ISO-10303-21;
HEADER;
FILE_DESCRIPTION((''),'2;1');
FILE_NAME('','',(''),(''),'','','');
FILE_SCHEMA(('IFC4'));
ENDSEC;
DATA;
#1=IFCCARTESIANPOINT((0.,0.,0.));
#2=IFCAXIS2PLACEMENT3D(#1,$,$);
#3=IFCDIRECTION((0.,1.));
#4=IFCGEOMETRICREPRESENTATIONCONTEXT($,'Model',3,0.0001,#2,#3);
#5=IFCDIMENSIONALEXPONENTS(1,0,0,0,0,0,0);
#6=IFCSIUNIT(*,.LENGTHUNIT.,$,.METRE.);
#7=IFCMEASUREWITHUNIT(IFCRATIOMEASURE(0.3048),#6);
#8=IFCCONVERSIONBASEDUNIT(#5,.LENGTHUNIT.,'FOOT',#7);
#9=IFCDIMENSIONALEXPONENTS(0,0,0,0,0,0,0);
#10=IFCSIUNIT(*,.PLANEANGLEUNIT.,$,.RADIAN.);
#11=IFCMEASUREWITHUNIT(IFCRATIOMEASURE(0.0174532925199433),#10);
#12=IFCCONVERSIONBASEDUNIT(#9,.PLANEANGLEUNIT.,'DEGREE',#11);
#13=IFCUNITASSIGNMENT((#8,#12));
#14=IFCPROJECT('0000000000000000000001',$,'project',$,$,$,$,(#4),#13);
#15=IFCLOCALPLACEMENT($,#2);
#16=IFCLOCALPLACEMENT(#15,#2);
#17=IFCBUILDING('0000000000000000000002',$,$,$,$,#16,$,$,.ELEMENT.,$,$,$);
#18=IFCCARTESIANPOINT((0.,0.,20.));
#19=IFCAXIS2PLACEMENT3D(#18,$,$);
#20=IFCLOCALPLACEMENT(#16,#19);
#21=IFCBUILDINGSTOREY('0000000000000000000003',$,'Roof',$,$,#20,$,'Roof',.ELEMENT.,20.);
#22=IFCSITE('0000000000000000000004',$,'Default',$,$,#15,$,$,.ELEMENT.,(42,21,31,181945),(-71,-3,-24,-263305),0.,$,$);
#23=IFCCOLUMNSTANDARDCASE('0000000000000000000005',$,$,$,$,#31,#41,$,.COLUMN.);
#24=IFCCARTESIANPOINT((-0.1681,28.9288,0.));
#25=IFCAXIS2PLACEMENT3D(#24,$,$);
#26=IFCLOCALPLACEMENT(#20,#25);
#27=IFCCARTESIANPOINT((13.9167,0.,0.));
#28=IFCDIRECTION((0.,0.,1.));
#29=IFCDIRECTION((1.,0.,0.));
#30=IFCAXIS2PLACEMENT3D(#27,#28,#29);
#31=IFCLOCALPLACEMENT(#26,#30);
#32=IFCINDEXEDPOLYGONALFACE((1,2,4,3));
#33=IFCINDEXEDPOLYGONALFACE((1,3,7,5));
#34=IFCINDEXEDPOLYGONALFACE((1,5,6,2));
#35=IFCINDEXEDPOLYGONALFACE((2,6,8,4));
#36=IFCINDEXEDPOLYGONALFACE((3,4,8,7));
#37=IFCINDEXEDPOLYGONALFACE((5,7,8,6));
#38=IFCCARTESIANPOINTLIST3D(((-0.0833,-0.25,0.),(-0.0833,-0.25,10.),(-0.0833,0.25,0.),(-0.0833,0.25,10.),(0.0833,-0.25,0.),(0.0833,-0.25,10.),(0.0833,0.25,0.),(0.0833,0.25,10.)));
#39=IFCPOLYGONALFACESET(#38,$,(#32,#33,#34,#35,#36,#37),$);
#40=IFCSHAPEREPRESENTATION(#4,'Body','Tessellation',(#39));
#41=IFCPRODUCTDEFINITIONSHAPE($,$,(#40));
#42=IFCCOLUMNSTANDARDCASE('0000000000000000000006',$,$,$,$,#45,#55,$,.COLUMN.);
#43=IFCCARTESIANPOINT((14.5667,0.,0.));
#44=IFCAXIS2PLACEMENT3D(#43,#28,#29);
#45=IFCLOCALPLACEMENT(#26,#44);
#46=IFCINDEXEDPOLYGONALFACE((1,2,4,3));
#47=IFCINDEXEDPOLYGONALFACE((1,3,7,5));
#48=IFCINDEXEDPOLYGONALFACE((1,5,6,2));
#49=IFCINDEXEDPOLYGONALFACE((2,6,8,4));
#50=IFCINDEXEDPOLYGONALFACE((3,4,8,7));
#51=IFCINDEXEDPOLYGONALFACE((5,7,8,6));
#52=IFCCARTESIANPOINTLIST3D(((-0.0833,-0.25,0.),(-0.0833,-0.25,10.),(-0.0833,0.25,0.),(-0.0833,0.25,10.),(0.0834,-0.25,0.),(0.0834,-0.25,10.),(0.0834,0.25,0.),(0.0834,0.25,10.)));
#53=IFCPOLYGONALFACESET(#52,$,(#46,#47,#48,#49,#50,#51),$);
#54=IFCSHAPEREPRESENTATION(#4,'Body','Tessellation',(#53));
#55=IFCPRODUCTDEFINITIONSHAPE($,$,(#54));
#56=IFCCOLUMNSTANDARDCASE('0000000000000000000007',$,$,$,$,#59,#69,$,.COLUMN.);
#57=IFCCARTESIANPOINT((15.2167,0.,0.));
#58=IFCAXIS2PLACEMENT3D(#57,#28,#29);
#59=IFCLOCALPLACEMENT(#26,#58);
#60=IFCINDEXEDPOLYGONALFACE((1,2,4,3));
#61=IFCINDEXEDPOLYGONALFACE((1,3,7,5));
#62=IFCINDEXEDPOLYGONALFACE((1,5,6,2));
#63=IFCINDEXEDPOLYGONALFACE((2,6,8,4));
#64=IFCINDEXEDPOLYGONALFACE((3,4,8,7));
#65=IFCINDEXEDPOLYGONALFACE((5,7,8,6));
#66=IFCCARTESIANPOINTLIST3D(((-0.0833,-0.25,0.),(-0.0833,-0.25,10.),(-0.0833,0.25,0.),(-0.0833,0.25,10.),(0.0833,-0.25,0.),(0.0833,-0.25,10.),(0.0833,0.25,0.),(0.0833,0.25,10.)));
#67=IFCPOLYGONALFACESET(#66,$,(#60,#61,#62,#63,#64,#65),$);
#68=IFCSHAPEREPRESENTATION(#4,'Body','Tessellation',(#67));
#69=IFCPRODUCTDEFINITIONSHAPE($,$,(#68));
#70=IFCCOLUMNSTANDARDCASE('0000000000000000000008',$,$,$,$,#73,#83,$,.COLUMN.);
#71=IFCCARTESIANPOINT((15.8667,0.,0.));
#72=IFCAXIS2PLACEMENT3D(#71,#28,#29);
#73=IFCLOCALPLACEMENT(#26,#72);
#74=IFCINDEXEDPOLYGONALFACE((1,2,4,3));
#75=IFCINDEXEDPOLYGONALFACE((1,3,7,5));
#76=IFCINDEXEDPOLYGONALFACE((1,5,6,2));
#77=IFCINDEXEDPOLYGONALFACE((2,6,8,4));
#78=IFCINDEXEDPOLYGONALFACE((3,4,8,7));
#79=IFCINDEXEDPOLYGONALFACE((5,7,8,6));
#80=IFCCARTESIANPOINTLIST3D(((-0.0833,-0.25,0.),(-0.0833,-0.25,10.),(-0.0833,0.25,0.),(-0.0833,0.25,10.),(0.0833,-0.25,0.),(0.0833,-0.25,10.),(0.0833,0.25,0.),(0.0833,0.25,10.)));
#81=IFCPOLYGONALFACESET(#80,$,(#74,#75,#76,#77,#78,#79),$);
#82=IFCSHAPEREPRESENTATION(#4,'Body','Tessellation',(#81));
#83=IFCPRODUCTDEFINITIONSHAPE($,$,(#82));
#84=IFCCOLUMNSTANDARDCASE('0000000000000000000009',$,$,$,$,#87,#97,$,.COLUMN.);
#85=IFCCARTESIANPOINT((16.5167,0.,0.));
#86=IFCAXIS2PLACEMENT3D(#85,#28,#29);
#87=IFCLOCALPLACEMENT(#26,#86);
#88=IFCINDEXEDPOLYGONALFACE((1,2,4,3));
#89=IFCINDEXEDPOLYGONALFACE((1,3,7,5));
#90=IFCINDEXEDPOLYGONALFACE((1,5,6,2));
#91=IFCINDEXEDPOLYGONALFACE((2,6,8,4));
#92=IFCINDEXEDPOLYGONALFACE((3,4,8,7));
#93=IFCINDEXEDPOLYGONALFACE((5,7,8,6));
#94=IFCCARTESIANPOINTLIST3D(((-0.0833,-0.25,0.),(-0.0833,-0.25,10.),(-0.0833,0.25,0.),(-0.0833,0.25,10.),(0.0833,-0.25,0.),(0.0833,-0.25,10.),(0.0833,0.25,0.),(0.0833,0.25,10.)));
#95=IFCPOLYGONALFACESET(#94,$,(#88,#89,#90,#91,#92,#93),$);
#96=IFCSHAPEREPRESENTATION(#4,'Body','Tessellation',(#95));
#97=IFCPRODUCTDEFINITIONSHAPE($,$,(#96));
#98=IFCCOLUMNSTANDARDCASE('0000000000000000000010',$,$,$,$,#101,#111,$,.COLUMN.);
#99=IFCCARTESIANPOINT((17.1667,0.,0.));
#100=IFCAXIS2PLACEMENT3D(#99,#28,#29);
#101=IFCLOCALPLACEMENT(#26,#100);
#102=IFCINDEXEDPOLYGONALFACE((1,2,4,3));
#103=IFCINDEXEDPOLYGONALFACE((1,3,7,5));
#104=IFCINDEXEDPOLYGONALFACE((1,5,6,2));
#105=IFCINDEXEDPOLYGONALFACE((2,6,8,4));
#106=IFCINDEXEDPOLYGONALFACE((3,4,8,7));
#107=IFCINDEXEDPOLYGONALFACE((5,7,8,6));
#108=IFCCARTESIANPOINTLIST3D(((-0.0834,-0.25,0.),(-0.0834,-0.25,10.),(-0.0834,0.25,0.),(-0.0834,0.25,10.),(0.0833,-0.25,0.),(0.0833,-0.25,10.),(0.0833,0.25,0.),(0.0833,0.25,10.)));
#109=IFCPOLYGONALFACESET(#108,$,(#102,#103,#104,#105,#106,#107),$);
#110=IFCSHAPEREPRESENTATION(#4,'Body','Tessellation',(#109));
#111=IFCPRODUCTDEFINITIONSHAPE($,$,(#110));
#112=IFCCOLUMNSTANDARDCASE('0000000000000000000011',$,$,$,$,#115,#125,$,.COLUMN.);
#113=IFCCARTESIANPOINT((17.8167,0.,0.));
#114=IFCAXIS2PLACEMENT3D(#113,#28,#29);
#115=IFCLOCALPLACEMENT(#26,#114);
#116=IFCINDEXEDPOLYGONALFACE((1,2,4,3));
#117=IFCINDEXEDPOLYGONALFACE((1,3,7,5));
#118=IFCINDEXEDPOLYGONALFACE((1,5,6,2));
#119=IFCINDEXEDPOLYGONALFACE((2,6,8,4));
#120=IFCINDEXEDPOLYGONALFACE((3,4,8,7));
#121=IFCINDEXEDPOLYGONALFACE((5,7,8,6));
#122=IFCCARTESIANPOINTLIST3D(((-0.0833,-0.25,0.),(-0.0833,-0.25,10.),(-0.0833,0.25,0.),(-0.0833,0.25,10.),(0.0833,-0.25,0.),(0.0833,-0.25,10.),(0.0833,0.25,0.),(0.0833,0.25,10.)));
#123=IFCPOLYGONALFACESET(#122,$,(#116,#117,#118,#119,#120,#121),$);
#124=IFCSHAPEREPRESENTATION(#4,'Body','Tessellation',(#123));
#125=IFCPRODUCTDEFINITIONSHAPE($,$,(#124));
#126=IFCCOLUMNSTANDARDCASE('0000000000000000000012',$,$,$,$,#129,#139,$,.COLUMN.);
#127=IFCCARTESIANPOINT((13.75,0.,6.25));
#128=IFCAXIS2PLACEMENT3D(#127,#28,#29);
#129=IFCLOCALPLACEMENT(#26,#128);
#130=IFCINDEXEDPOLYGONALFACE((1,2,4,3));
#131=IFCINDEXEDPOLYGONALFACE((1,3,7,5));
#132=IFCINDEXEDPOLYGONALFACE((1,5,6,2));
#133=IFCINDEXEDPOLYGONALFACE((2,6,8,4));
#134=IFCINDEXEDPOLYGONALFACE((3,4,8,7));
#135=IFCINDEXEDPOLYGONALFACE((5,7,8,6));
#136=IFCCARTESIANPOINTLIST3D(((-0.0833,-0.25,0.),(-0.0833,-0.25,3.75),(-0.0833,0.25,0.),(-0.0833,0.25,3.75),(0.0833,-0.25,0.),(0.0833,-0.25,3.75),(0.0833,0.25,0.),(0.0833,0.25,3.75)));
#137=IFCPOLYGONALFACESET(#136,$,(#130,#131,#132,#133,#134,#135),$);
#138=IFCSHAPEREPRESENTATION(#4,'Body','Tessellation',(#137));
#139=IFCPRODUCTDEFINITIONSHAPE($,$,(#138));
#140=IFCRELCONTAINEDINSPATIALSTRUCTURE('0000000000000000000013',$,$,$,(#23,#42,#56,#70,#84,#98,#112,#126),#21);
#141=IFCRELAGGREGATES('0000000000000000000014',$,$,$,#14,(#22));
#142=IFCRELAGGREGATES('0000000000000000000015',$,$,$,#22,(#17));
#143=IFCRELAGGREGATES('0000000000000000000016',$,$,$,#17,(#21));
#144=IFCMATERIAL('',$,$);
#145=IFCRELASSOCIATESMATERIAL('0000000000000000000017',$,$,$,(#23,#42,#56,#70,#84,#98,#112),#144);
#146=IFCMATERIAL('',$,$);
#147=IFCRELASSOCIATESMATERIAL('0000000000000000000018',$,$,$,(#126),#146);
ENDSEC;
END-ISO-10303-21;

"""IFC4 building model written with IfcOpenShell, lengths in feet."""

from ifc_helpers import new_model, entity, si_unit, converted_unit, direction, frame, origin, place, context, project, spatial, rectangle, extrude, material, element, save


model = new_model("IFC4")

# Units and contexts
model_context = context("Model", 3, precision=0.0001, world=origin(), true_north=direction((0.0, 1.0)))
ifc_project = project(units=[converted_unit("LENGTHUNIT", "FOOT", entity("IfcRatioMeasure", 0.3048), si_unit("LENGTHUNIT", "METRE"), dimensions=[1, 0, 0, 0, 0, 0, 0]), converted_unit("PLANEANGLEUNIT", "DEGREE", entity("IfcRatioMeasure", 0.0174532925199433), si_unit("PLANEANGLEUNIT", "RADIAN"), dimensions=[0, 0, 0, 0, 0, 0, 0])], contexts=[model_context])

# Site, building, storey
site_placement = place(None, origin())
site = spatial("IfcSite", under=ifc_project, at=site_placement, Name="Default", CompositionType="ELEMENT", RefLatitude=(42, 21, 31, 181945), RefLongitude=(-71, -3, -24, -263305), RefElevation=0.0)
building_placement = place(site_placement, origin())
building = spatial("IfcBuilding", under=site, at=building_placement, CompositionType="ELEMENT")
storey_placement = place(building_placement, frame((0.0, 0.0, 20.0)))
storey = spatial("IfcBuildingStorey", under=building, at=storey_placement, Name="Roof", LongName="Roof", CompositionType="ELEMENT", Elevation=20.0)

# Columns
ifc_material_1 = material(Name="")
placement = place(storey_placement, frame((-0.1681, 28.9288, 0.0)))
for number, where, z_axis, x_axis in (
    (1, (13.9167, 0.0, 0.0), (0.0, 0.0, 1.0), (1.0, 0.0, 0.0)),
    (2, (14.5667, 0.0, 0.0), (0.0, 0.0, 1.0), (1.0, 0.0, 0.0)),
    (3, (15.2167, 0.0, 0.0), (0.0, 0.0, 1.0), (1.0, 0.0, 0.0)),
    (4, (15.8667, 0.0, 0.0), (0.0, 0.0, 1.0), (1.0, 0.0, 0.0)),
    (5, (16.5167, 0.0, 0.0), (0.0, 0.0, 1.0), (1.0, 0.0, 0.0)),
    (6, (17.1667, 0.0, 0.0), (0.0, 0.0, 1.0), (1.0, 0.0, 0.0)),
    (7, (17.8167, 0.0, 0.0), (0.0, 0.0, 1.0), (1.0, 0.0, 0.0)),
):
    element("IfcColumnStandardCase", number, at=place(placement, frame(where, z_axis=z_axis, x_axis=x_axis)), inside=storey, material=ifc_material_1, PredefinedType="COLUMN", context=model_context, shape_type="SweptSolid", body=[
        extrude(rectangle(XDim=0.1667, YDim=0.5), origin(), (0.0, 0.0, 1.0), 10.0),
    ])
ifc_material_2 = material(Name="")
for number, where, z_axis, x_axis in (
    (8, (13.75, 0.0, 6.25), (0.0, 0.0, 1.0), (1.0, 0.0, 0.0)),
):
    element("IfcColumnStandardCase", number, at=place(placement, frame(where, z_axis=z_axis, x_axis=x_axis)), inside=storey, material=ifc_material_2, PredefinedType="COLUMN", context=model_context, shape_type="SweptSolid", body=[
        extrude(rectangle(XDim=0.1667, YDim=0.5), origin(), (0.0, 0.0, 1.0), 3.75),
    ])

save(model, "model.ifc")
